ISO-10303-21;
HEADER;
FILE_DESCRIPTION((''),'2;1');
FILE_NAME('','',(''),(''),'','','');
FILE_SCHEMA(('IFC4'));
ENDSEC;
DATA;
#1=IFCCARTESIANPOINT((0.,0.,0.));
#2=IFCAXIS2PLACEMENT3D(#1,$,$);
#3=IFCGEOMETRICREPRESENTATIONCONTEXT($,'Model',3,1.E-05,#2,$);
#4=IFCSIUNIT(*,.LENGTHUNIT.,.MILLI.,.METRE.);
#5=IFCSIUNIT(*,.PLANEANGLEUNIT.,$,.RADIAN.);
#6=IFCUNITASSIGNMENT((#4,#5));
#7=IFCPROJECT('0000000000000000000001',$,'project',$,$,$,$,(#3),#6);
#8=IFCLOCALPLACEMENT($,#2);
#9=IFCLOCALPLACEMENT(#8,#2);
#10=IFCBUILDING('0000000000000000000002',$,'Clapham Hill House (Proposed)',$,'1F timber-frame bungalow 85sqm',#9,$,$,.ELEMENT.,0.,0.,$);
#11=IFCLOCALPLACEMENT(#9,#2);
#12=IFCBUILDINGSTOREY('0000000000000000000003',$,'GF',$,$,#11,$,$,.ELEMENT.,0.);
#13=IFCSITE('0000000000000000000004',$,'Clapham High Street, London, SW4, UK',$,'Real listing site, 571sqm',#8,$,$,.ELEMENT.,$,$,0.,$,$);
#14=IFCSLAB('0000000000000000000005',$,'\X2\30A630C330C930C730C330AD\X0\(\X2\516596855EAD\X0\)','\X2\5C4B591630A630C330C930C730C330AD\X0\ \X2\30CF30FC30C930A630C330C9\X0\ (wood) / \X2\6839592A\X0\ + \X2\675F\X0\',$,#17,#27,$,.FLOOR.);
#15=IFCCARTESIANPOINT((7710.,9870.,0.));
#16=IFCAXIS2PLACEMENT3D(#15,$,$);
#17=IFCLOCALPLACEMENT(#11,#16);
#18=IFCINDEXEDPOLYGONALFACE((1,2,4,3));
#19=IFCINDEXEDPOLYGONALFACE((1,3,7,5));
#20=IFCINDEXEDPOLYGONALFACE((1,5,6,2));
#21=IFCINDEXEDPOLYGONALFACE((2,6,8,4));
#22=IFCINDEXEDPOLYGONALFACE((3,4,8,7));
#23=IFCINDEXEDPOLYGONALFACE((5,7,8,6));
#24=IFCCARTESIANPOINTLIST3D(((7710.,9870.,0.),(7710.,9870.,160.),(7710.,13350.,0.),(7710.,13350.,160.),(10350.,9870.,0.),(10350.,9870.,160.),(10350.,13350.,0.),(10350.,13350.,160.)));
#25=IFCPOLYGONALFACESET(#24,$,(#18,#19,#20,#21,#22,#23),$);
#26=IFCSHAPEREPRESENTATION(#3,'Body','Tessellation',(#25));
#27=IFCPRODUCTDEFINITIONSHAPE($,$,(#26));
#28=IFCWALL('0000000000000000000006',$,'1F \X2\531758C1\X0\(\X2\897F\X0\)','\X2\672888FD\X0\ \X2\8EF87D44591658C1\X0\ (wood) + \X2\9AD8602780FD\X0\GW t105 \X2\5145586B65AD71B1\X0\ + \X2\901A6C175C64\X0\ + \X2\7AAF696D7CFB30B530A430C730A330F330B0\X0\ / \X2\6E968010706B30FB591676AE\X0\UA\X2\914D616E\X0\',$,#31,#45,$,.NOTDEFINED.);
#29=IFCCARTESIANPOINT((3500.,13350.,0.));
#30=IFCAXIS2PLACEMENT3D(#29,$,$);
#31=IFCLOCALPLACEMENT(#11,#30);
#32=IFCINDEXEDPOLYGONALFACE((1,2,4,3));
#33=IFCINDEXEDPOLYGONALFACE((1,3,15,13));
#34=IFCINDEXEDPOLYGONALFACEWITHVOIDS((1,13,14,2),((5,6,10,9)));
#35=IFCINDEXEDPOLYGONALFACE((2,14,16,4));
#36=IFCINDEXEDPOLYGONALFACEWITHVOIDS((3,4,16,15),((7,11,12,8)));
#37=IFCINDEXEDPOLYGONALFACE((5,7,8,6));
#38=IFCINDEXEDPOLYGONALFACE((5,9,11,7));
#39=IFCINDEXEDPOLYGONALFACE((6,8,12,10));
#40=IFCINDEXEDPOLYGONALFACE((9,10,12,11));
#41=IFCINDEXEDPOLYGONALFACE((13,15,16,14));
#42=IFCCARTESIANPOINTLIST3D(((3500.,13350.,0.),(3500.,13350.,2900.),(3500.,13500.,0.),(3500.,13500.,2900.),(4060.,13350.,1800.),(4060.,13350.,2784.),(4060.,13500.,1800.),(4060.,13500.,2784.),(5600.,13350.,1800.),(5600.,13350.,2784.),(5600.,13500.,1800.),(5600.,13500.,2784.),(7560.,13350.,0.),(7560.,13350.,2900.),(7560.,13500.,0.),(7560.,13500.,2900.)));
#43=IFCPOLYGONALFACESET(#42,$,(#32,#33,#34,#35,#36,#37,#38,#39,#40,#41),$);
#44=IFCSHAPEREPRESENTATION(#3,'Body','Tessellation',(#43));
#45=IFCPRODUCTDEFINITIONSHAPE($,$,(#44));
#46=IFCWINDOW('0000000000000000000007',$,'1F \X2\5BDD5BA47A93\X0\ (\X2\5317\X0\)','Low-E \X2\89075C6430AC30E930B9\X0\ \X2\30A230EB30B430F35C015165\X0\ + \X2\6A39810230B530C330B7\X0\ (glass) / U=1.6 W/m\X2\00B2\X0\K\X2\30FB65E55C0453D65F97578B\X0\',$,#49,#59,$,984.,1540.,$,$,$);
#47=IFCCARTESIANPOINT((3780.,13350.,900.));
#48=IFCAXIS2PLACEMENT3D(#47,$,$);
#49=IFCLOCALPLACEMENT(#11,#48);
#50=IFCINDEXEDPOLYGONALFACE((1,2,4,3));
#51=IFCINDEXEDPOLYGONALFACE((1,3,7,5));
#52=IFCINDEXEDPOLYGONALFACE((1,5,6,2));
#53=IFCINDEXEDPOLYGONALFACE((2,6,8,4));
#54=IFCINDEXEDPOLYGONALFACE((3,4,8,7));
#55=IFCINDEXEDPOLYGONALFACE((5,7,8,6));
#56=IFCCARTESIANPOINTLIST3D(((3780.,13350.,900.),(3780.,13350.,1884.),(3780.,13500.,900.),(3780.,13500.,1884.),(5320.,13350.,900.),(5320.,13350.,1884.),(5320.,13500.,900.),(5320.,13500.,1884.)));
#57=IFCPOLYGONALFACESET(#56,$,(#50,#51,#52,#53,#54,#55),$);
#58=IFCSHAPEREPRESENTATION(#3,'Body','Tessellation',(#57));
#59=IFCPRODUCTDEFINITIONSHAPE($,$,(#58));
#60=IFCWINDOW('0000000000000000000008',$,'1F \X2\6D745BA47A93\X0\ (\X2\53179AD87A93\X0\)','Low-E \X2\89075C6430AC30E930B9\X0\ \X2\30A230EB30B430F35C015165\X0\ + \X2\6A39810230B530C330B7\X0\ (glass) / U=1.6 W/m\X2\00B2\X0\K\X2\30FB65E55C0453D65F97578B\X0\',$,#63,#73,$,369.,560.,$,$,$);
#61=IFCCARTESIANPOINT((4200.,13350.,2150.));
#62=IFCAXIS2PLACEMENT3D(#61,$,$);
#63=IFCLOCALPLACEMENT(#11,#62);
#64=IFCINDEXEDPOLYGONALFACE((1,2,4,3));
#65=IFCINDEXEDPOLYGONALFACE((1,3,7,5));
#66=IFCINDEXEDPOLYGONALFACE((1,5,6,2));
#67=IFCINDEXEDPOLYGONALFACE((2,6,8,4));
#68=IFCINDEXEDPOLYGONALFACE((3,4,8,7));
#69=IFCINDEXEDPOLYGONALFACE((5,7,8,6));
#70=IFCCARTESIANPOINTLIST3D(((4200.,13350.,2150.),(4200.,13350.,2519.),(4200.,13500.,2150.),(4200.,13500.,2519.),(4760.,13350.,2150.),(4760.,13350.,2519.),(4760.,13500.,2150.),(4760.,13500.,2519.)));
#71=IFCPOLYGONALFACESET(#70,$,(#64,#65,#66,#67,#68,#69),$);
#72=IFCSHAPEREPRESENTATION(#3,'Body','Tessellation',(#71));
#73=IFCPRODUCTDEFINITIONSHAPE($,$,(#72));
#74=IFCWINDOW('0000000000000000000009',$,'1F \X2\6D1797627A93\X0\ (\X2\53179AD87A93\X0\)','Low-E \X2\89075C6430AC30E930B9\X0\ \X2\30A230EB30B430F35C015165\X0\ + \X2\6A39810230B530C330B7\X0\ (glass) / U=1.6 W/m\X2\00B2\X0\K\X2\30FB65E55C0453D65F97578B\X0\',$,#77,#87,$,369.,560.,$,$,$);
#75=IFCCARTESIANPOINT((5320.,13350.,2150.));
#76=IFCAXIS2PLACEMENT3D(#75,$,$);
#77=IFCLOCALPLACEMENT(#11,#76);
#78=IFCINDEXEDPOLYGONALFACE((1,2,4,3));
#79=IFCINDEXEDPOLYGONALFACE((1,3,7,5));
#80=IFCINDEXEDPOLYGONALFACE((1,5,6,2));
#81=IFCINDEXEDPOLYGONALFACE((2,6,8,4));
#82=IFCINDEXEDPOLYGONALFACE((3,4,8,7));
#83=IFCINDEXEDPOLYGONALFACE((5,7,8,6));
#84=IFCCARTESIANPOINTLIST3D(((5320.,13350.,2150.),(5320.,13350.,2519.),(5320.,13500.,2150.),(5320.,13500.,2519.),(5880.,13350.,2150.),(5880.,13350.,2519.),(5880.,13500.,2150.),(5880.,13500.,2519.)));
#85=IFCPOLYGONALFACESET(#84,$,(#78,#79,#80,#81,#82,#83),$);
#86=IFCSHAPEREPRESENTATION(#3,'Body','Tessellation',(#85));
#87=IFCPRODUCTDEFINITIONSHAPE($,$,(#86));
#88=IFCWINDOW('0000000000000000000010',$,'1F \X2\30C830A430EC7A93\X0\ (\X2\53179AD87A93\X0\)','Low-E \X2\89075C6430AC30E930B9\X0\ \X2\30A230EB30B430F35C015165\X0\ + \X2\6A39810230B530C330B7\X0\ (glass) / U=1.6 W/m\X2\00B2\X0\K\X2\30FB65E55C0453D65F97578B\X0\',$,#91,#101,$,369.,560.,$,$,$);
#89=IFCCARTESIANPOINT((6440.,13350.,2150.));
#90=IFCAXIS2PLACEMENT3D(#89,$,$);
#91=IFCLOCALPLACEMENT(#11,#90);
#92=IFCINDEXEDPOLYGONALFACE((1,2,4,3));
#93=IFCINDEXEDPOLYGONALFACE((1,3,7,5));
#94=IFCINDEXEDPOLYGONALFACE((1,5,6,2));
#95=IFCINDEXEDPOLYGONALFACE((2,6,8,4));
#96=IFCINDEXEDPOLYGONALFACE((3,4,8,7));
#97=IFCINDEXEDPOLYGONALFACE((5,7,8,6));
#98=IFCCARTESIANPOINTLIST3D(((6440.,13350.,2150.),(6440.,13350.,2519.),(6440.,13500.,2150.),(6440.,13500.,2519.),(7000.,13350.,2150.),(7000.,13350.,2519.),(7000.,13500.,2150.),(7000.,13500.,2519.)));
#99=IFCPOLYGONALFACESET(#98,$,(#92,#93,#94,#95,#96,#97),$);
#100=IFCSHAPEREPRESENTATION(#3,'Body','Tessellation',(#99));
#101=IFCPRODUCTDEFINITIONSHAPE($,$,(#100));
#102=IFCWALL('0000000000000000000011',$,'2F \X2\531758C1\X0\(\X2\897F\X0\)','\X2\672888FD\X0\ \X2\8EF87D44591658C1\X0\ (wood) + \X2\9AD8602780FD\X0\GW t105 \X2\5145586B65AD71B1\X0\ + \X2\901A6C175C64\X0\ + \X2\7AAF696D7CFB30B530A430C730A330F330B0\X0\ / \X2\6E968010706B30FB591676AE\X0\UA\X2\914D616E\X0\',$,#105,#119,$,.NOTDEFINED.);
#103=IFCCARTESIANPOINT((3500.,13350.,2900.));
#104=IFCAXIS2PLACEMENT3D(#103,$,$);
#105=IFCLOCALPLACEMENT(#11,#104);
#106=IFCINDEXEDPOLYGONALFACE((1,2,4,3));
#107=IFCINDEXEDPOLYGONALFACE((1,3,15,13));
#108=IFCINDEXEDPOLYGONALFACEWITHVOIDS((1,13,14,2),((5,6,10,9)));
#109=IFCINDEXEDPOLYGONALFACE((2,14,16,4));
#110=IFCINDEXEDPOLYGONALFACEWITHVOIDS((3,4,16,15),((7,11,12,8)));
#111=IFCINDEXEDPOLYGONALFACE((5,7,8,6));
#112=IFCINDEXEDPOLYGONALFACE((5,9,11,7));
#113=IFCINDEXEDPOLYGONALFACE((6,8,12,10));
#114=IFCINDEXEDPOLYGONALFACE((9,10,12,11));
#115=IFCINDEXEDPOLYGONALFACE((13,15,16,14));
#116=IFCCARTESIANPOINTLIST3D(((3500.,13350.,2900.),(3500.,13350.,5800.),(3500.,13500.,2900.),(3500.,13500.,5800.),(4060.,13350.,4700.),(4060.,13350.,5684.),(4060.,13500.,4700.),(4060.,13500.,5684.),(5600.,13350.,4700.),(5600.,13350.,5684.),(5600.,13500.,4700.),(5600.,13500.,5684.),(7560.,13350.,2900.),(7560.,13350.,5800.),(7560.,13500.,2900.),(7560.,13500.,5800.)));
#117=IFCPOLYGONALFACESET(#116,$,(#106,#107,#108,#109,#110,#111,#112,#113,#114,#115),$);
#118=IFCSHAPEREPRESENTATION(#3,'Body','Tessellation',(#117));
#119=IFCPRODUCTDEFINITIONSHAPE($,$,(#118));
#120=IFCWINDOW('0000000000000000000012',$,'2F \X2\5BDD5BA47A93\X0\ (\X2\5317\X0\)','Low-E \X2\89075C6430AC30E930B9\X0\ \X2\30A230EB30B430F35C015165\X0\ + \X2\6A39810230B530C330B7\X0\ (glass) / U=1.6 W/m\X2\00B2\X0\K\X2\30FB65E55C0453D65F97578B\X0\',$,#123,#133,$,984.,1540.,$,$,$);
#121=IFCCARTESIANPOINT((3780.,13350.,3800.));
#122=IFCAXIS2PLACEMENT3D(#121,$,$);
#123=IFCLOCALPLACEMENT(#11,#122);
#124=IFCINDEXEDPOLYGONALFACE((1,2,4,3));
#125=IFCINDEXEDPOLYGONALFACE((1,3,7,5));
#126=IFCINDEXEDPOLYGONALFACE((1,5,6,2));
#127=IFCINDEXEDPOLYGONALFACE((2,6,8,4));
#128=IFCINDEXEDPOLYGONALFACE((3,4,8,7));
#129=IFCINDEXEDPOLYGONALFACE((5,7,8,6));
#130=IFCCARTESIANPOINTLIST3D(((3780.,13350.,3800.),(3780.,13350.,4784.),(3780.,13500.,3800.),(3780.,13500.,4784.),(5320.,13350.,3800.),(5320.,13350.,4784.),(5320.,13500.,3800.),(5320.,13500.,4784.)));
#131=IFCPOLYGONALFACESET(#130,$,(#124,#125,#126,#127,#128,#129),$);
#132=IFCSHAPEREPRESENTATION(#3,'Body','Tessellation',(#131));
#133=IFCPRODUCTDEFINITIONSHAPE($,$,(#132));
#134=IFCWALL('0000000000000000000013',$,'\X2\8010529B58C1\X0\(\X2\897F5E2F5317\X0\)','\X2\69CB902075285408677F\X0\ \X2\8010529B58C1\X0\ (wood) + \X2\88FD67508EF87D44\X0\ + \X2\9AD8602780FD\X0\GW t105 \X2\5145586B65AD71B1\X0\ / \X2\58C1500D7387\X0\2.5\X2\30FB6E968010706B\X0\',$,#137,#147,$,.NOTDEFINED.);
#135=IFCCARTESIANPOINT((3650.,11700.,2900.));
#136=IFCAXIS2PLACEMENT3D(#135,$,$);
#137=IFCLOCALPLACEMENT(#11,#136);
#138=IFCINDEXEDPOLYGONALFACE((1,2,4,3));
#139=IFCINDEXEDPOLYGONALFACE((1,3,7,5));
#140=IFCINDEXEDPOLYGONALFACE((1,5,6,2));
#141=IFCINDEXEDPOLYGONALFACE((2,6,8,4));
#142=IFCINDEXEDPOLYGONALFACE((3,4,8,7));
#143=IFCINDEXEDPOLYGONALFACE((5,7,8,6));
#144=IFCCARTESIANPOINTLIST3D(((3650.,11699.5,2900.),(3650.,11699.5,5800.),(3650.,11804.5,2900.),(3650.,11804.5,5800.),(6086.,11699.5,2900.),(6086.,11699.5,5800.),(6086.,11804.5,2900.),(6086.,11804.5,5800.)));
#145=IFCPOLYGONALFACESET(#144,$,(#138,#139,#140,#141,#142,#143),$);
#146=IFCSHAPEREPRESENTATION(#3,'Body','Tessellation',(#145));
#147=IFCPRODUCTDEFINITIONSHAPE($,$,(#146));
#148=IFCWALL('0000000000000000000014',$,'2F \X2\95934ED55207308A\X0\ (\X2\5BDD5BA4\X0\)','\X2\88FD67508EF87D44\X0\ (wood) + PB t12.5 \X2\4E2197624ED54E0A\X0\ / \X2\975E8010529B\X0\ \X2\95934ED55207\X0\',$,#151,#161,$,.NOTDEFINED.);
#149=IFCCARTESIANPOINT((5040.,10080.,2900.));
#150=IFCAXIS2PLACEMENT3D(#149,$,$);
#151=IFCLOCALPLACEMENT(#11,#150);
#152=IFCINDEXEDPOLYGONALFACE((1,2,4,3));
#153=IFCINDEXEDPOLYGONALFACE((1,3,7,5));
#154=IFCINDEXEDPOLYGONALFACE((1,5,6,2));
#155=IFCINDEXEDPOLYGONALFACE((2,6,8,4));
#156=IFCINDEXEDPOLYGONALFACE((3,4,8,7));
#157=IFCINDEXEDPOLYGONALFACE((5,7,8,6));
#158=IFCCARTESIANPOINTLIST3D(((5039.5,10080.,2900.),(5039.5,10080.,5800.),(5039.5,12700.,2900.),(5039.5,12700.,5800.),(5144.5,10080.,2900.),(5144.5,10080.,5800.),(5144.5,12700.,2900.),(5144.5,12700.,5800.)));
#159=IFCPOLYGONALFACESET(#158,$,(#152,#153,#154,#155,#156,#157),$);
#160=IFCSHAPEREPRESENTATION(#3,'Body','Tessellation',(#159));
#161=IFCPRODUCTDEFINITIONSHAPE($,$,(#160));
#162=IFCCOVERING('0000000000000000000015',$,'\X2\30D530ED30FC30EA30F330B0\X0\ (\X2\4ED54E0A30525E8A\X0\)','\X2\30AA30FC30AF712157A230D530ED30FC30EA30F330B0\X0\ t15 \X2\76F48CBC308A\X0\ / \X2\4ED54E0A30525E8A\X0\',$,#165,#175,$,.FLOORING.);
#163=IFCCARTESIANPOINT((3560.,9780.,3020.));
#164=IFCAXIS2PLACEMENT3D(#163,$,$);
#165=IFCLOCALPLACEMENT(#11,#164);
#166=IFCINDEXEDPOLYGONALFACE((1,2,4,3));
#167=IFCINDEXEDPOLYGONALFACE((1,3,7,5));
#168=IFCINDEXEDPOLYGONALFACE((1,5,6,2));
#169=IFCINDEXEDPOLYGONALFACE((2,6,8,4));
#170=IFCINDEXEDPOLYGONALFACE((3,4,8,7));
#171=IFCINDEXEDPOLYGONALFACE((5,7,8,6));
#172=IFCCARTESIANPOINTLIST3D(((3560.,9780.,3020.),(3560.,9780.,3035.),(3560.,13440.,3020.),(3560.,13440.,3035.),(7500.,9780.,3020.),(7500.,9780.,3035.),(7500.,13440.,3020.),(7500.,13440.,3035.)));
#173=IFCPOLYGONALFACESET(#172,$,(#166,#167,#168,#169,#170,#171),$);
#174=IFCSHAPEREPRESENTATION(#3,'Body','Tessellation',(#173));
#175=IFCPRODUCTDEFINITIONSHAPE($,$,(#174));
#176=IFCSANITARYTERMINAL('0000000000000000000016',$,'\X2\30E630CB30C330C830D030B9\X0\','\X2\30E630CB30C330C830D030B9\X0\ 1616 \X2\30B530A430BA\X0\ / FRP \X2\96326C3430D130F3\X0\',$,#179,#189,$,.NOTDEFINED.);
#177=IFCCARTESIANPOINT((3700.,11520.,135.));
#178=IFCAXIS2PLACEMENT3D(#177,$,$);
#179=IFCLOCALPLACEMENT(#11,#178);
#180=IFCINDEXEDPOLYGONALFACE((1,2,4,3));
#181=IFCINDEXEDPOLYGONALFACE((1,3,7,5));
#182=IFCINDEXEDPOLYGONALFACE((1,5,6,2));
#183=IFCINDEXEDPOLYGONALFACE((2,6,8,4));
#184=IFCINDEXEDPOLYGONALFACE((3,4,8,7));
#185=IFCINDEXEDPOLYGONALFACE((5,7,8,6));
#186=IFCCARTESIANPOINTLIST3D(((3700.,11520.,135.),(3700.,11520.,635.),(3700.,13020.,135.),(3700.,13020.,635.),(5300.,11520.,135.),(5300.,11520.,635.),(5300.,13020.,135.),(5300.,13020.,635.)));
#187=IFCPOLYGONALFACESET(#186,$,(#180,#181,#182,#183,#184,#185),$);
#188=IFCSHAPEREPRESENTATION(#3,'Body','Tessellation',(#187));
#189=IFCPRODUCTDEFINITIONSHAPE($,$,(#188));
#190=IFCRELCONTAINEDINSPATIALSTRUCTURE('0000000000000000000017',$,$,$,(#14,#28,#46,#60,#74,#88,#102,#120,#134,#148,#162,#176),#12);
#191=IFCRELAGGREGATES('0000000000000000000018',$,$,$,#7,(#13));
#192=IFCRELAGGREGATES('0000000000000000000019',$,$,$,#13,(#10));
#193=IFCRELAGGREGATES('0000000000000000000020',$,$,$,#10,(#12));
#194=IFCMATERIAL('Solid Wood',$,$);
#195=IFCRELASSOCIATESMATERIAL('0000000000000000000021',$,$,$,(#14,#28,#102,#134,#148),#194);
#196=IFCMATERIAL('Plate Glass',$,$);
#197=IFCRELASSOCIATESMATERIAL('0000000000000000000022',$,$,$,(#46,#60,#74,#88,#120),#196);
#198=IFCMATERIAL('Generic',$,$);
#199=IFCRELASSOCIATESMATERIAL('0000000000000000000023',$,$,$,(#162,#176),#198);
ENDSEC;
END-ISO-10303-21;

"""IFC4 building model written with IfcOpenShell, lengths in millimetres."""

from ifc_helpers import new_model, si_unit, frame, frame_2d, origin, place, context, project, spatial, rectangle, extrude, material, element, fill, save


model = new_model("IFC4")

# Units and contexts
model_context = context("Model", 3, precision=1e-05, world=origin())
ifc_project = project(units=[si_unit("LENGTHUNIT", "METRE", prefix="MILLI"), si_unit("PLANEANGLEUNIT", "RADIAN")], contexts=[model_context])

# Site, building, storey
site_placement = place(None, origin())
site = spatial("IfcSite", under=ifc_project, at=site_placement, Name="Clapham High Street, London, SW4, UK", ObjectType="Real listing site, 571sqm", CompositionType="ELEMENT", RefElevation=0.0)
building_placement = place(site_placement, origin())
building = spatial("IfcBuilding", under=site, at=building_placement, Name="Clapham Hill House (Proposed)", ObjectType="1F timber-frame bungalow 85sqm", CompositionType="ELEMENT", ElevationOfRefHeight=0.0, ElevationOfTerrain=0.0)
storey_placement = place(building_placement, origin())
storey = spatial("IfcBuildingStorey", under=building, at=storey_placement, Name="GF", CompositionType="ELEMENT", Elevation=0.0)

# Slab
ifc_material_1 = material(Name="Solid Wood")
slab_placement = place(storey_placement, frame((7710.0, 9870.0, 0.0)))
element("IfcSlab", 1, at=slab_placement, inside=storey, material=ifc_material_1, Name="ウッドデッキ(入隅庭)", Description="屋外ウッドデッキ ハードウッド (wood) / 根太 + 束", PredefinedType="FLOOR", context=model_context, shape_type="SweptSolid", body=[
    extrude(rectangle(XDim=2640.0, YDim=3480.0, at=frame_2d((1320.0, 1740.0))), frame((7710.0, 9870.0, 0.0)), (0.0, 0.0, 1.0), 160.0),
])

# Wall, openings, windows
wall_1_placement = place(storey_placement, frame((3500.0, 13350.0, 0.0)))
wall_1 = element("IfcWall", 2, at=wall_1_placement, inside=storey, material=ifc_material_1, Name="1F 北壁(西)", Description="木製 軸組外壁 (wood) + 高性能GW t105 充填断熱 + 通気層 + 窯業系サイディング / 準耐火・外皮UA配慮", PredefinedType="NOTDEFINED", context=model_context, shape_type="SweptSolid", body=[
    extrude(rectangle(XDim=4060.0, YDim=150.0, at=frame_2d((2030.0, 75.0))), frame((3500.0, 13350.0, 0.0)), (0.0, 0.0, 1.0), 2900.0),
])
opening_1_placement = place(storey_placement, frame((3780.0, 13350.0, 900.0)))
opening_1 = element("IfcOpeningElement", 3, at=opening_1_placement, cuts=wall_1, PredefinedType="NOTDEFINED", context=model_context, shape_type="SweptSolid", body=[
    extrude(rectangle(XDim=1540.0, YDim=150.0, at=frame_2d((770.0, 75.0))), frame((3780.0, 13350.0, 900.0)), (0.0, 0.0, 1.0), 984.0),
])
opening_2_placement = place(storey_placement, frame((4200.0, 13350.0, 2150.0)))
opening_2 = element("IfcOpeningElement", 4, at=opening_2_placement, cuts=wall_1, PredefinedType="NOTDEFINED", context=model_context, shape_type="SweptSolid", body=[
    extrude(rectangle(XDim=560.0, YDim=150.0, at=frame_2d((280.0, 75.0))), frame((4200.0, 13350.0, 2150.0)), (0.0, 0.0, 1.0), 369.0),
])
opening_3_placement = place(storey_placement, frame((5320.0, 13350.0, 2150.0)))
opening_3 = element("IfcOpeningElement", 5, at=opening_3_placement, cuts=wall_1, PredefinedType="NOTDEFINED", context=model_context, shape_type="SweptSolid", body=[
    extrude(rectangle(XDim=560.0, YDim=150.0, at=frame_2d((280.0, 75.0))), frame((5320.0, 13350.0, 2150.0)), (0.0, 0.0, 1.0), 369.0),
])
opening_4_placement = place(storey_placement, frame((6440.0, 13350.0, 2150.0)))
opening_4 = element("IfcOpeningElement", 6, at=opening_4_placement, cuts=wall_1, PredefinedType="NOTDEFINED", context=model_context, shape_type="SweptSolid", body=[
    extrude(rectangle(XDim=560.0, YDim=150.0, at=frame_2d((280.0, 75.0))), frame((6440.0, 13350.0, 2150.0)), (0.0, 0.0, 1.0), 369.0),
])
ifc_material_2 = material(Name="Plate Glass")
window_1_placement = place(storey_placement, frame((3780.0, 13350.0, 900.0)))
window_1 = element("IfcWindow", 7, at=window_1_placement, inside=storey, material=ifc_material_2, Name="1F 寝室窓 (北)", Description="Low-E 複層ガラス アルゴン封入 + 樹脂サッシ (glass) / U=1.6 W/m²K・日射取得型", OverallHeight=984.0, OverallWidth=1540.0, context=model_context, shape_type="SweptSolid", body=[
    extrude(rectangle(XDim=1540.0, YDim=150.0, at=frame_2d((770.0, 75.0))), frame((3780.0, 13350.0, 900.0)), (0.0, 0.0, 1.0), 984.0),
])
fill(opening_1, window_1)
window_2_placement = place(storey_placement, frame((4200.0, 13350.0, 2150.0)))
window_2 = element("IfcWindow", 8, at=window_2_placement, inside=storey, material=ifc_material_2, Name="1F 浴室窓 (北高窓)", Description="Low-E 複層ガラス アルゴン封入 + 樹脂サッシ (glass) / U=1.6 W/m²K・日射取得型", OverallHeight=369.0, OverallWidth=560.0, context=model_context, shape_type="SweptSolid", body=[
    extrude(rectangle(XDim=560.0, YDim=150.0, at=frame_2d((280.0, 75.0))), frame((4200.0, 13350.0, 2150.0)), (0.0, 0.0, 1.0), 369.0),
])
fill(opening_2, window_2)
window_3_placement = place(storey_placement, frame((5320.0, 13350.0, 2150.0)))
window_3 = element("IfcWindow", 9, at=window_3_placement, inside=storey, material=ifc_material_2, Name="1F 洗面窓 (北高窓)", Description="Low-E 複層ガラス アルゴン封入 + 樹脂サッシ (glass) / U=1.6 W/m²K・日射取得型", OverallHeight=369.0, OverallWidth=560.0, context=model_context, shape_type="SweptSolid", body=[
    extrude(rectangle(XDim=560.0, YDim=150.0, at=frame_2d((280.0, 75.0))), frame((5320.0, 13350.0, 2150.0)), (0.0, 0.0, 1.0), 369.0),
])
fill(opening_3, window_3)
window_4_placement = place(storey_placement, frame((6440.0, 13350.0, 2150.0)))
window_4 = element("IfcWindow", 10, at=window_4_placement, inside=storey, material=ifc_material_2, Name="1F トイレ窓 (北高窓)", Description="Low-E 複層ガラス アルゴン封入 + 樹脂サッシ (glass) / U=1.6 W/m²K・日射取得型", OverallHeight=369.0, OverallWidth=560.0, context=model_context, shape_type="SweptSolid", body=[
    extrude(rectangle(XDim=560.0, YDim=150.0, at=frame_2d((280.0, 75.0))), frame((6440.0, 13350.0, 2150.0)), (0.0, 0.0, 1.0), 369.0),
])
fill(opening_4, window_4)

# Wall, opening, window
wall_2_placement = place(storey_placement, frame((3500.0, 13350.0, 2900.0)))
wall_2 = element("IfcWall", 11, at=wall_2_placement, inside=storey, material=ifc_material_1, Name="2F 北壁(西)", Description="木製 軸組外壁 (wood) + 高性能GW t105 充填断熱 + 通気層 + 窯業系サイディング / 準耐火・外皮UA配慮", PredefinedType="NOTDEFINED", context=model_context, shape_type="SweptSolid", body=[
    extrude(rectangle(XDim=4060.0, YDim=150.0, at=frame_2d((2030.0, 75.0))), frame((3500.0, 13350.0, 2900.0)), (0.0, 0.0, 1.0), 2900.0),
])
opening_5_placement = place(storey_placement, frame((3780.0, 13350.0, 3800.0)))
opening_5 = element("IfcOpeningElement", 12, at=opening_5_placement, cuts=wall_2, PredefinedType="NOTDEFINED", context=model_context, shape_type="SweptSolid", body=[
    extrude(rectangle(XDim=1540.0, YDim=150.0, at=frame_2d((770.0, 75.0))), frame((3780.0, 13350.0, 3800.0)), (0.0, 0.0, 1.0), 984.0),
])
window_5_placement = place(storey_placement, frame((3780.0, 13350.0, 3800.0)))
window_5 = element("IfcWindow", 13, at=window_5_placement, inside=storey, material=ifc_material_2, Name="2F 寝室窓 (北)", Description="Low-E 複層ガラス アルゴン封入 + 樹脂サッシ (glass) / U=1.6 W/m²K・日射取得型", OverallHeight=984.0, OverallWidth=1540.0, context=model_context, shape_type="SweptSolid", body=[
    extrude(rectangle(XDim=1540.0, YDim=150.0, at=frame_2d((770.0, 75.0))), frame((3780.0, 13350.0, 3800.0)), (0.0, 0.0, 1.0), 984.0),
])
fill(opening_5, window_5)

# Walls
wall_3_placement = place(storey_placement, frame((3650.0, 11700.0, 2900.0)))
element("IfcWall", 14, at=wall_3_placement, inside=storey, material=ifc_material_1, Name="耐力壁(西帯北)", Description="構造用合板 耐力壁 (wood) + 製材軸組 + 高性能GW t105 充填断熱 / 壁倍率2.5・準耐火", PredefinedType="NOTDEFINED", context=model_context, shape_type="SweptSolid", body=[
    extrude(rectangle(XDim=2436.0, YDim=105.0, at=frame_2d((1218.0, 52.0))), frame((3650.0, 11700.0, 2900.0)), (0.0, 0.0, 1.0), 2900.0),
])
wall_4_placement = place(storey_placement, frame((5040.0, 10080.0, 2900.0)))
element("IfcWall", 15, at=wall_4_placement, inside=storey, material=ifc_material_1, Name="2F 間仕切り (寝室)", Description="製材軸組 (wood) + PB t12.5 両面仕上 / 非耐力 間仕切", PredefinedType="NOTDEFINED", context=model_context, shape_type="SweptSolid", body=[
    extrude(rectangle(XDim=105.0, YDim=2620.0, at=frame_2d((52.0, 1310.0))), frame((5040.0, 10080.0, 2900.0)), (0.0, 0.0, 1.0), 2900.0),
])

# Covering
ifc_material_3 = material(Name="Generic")
covering_placement = place(storey_placement, frame((3560.0, 9780.0, 3020.0)))
element("IfcCovering", 16, at=covering_placement, inside=storey, material=ifc_material_3, Name="フローリング (仕上げ床)", Description="オーク無垢フローリング t15 直貼り / 仕上げ床", PredefinedType="FLOORING", context=model_context, shape_type="SweptSolid", body=[
    extrude(rectangle(XDim=3940.0, YDim=3660.0, at=frame_2d((1970.0, 1830.0))), frame((3560.0, 9780.0, 3020.0)), (0.0, 0.0, 1.0), 15.0),
])

# Sanitary terminal
sanitary_terminal_1_placement = place(storey_placement, frame((3700.0, 11520.0, 135.0)))
element("IfcSanitaryTerminal", 17, at=sanitary_terminal_1_placement, inside=storey, material=ifc_material_3, Name="ユニットバス", Description="ユニットバス 1616 サイズ / FRP 防水パン", PredefinedType="NOTDEFINED", context=model_context, shape_type="SweptSolid", body=[
    extrude(rectangle(XDim=1600.0, YDim=1500.0, at=frame_2d((800.0, 750.0))), frame((3700.0, 11520.0, 135.0)), (0.0, 0.0, 1.0), 500.0),
])

save(model, "model.ifc")
